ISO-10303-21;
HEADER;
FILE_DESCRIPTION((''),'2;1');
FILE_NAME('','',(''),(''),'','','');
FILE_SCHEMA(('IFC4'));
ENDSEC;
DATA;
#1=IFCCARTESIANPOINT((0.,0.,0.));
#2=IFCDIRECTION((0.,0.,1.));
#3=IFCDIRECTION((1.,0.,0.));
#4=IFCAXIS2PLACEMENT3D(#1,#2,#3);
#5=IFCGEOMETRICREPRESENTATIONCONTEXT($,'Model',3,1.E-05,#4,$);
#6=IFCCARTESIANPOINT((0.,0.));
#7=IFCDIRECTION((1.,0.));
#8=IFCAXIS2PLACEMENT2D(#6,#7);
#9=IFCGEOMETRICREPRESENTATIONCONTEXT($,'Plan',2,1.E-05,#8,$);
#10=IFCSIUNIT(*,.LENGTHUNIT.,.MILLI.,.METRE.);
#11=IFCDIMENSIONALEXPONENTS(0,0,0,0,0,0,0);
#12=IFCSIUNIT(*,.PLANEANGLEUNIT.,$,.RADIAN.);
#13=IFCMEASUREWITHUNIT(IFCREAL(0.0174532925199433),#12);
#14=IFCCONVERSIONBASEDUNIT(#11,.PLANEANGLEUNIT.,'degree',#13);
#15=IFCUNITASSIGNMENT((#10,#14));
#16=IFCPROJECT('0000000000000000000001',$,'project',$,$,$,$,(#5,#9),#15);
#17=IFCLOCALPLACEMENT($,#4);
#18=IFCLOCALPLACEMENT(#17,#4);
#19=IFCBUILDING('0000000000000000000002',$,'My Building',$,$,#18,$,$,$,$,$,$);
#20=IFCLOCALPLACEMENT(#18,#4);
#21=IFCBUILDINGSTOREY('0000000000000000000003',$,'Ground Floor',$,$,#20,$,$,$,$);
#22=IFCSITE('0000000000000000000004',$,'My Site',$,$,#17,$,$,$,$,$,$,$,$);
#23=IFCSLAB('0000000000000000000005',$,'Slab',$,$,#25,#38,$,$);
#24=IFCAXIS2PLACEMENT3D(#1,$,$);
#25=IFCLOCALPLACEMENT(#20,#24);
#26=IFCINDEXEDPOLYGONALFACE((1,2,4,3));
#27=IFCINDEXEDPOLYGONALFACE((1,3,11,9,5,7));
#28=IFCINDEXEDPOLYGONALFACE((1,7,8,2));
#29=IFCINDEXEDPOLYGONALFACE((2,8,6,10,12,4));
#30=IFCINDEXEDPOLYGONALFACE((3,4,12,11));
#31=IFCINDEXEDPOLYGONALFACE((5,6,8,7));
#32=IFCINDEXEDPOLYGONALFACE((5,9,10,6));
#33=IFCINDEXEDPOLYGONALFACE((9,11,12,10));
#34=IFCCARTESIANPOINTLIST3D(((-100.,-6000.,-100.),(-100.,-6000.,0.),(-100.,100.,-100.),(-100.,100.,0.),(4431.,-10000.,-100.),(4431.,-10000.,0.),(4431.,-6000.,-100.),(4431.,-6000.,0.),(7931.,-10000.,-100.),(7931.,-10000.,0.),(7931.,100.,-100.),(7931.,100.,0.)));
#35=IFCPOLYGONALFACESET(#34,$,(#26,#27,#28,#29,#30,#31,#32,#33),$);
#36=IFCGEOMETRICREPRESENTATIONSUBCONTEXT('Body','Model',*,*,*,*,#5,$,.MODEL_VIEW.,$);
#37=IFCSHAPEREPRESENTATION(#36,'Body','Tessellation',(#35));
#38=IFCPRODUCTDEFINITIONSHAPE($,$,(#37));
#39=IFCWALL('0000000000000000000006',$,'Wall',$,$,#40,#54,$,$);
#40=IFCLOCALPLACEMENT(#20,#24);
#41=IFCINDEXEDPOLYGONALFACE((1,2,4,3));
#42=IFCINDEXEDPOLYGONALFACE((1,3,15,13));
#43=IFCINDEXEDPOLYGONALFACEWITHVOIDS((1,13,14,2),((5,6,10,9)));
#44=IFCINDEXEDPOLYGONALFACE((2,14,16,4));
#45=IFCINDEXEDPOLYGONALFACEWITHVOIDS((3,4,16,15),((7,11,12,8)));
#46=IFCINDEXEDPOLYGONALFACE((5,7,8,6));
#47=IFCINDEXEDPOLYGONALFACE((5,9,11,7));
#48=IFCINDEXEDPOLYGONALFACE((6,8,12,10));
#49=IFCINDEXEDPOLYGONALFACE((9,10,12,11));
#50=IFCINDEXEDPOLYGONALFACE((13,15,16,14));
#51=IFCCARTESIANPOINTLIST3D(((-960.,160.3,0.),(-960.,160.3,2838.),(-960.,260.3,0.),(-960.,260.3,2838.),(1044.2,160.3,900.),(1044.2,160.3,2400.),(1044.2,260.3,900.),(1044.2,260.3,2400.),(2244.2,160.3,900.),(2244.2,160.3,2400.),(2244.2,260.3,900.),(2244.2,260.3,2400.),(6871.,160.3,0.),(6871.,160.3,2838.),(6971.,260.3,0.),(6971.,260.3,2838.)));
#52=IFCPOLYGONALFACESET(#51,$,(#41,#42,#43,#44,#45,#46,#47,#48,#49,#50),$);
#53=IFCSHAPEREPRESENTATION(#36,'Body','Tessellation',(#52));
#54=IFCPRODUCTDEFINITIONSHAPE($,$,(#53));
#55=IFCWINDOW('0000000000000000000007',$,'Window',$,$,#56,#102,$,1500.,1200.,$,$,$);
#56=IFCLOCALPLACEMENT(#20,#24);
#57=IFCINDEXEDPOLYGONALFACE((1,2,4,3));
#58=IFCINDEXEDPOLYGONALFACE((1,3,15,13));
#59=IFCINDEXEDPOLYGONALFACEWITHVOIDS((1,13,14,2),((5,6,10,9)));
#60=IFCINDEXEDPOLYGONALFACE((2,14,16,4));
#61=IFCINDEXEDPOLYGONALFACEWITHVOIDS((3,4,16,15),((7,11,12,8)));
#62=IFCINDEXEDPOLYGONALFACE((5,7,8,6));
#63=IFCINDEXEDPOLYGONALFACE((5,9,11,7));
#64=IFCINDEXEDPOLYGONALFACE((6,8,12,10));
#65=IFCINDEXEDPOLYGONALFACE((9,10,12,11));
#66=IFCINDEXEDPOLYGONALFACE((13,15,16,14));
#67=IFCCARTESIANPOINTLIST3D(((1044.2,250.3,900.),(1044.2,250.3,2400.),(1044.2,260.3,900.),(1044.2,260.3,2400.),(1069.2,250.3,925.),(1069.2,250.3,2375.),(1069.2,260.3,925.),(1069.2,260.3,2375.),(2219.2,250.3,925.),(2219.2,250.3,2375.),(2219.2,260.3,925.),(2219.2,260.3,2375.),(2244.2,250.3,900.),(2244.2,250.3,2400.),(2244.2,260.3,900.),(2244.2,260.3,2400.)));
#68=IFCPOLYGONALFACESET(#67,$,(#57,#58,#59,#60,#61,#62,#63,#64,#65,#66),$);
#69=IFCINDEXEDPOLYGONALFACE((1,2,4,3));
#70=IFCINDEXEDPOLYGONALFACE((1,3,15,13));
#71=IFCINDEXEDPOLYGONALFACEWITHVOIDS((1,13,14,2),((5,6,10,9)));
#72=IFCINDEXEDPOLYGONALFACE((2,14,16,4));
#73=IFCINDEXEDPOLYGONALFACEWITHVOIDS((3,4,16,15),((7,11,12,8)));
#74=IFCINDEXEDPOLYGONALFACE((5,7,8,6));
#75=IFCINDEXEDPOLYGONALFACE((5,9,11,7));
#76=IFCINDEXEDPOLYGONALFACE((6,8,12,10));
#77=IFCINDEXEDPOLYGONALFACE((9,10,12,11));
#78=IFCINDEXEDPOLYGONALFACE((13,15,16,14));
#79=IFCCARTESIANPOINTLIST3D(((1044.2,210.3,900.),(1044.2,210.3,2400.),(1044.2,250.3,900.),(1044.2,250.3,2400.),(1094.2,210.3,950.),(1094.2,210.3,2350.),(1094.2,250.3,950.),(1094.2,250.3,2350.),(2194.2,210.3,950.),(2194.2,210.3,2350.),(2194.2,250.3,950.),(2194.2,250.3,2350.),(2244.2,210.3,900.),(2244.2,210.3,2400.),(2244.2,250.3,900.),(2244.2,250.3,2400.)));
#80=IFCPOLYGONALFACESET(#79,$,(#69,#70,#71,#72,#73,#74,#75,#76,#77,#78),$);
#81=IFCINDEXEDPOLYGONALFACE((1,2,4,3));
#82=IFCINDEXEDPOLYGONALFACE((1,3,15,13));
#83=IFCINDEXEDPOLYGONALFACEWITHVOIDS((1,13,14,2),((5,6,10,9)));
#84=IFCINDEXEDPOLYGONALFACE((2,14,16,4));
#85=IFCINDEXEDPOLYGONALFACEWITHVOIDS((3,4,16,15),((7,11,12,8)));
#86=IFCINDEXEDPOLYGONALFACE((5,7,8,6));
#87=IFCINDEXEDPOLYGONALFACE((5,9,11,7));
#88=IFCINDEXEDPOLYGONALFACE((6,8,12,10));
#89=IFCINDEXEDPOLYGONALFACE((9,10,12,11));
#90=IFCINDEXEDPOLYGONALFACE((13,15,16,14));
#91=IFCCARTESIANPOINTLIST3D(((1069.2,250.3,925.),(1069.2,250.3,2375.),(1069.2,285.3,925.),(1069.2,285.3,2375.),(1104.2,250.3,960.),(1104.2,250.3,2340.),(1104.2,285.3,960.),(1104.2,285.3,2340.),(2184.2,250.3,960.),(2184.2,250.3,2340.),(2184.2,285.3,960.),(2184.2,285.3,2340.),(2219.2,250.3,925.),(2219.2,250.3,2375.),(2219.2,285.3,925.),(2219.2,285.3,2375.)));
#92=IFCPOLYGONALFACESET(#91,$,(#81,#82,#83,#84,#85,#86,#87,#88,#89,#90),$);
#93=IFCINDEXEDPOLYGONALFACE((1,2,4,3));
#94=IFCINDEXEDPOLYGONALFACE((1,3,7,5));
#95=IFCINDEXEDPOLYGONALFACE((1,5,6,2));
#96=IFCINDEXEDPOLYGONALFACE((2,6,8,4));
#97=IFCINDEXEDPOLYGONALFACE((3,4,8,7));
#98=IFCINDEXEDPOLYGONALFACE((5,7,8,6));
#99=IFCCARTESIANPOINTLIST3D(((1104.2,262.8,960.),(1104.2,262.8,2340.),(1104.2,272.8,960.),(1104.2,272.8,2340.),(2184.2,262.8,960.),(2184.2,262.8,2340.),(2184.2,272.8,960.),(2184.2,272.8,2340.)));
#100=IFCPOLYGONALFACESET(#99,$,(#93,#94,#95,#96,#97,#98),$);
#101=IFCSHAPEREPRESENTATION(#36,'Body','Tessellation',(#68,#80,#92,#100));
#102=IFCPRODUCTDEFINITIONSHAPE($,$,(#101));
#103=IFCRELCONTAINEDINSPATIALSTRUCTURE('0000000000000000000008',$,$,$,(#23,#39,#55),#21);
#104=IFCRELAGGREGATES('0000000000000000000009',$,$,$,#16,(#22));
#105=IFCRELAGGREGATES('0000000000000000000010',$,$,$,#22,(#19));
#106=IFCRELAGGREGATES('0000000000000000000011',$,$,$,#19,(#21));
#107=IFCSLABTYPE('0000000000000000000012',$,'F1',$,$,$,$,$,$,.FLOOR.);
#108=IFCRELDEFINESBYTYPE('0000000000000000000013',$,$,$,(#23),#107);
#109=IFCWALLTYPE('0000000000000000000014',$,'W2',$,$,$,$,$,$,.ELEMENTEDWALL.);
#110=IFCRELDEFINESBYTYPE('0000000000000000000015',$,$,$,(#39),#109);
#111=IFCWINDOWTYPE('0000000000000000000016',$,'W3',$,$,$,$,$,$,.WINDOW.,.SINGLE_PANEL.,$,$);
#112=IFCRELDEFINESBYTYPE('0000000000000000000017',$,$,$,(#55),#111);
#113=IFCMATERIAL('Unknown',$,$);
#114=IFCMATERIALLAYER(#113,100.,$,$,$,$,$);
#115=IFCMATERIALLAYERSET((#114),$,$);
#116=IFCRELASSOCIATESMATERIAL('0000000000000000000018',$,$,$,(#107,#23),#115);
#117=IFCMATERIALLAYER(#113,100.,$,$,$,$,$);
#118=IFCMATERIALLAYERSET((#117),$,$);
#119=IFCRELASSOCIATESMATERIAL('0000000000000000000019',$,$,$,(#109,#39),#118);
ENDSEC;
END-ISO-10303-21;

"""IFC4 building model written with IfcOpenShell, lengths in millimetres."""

from ifc_helpers import new_model, entity, si_unit, converted_unit, frame, origin_with_axes, origin_2d_with_axis, place, context, subcontext, project, spatial, line, indexed_curve, outline, extrude, clip, halfspace, shape, source, transform, mapped, material, layer, layer_set, layer_usage, type_object, type_shapes, element, fill, save


model = new_model("IFC4")

# Units and contexts
model_context = context("Model", 3, precision=1e-05, world=origin_with_axes())
plan_context = context("Plan", 2, precision=1e-05, world=origin_2d_with_axis())
body_context_1 = subcontext(model_context, "Body", "Model", "MODEL_VIEW")
body_context_2 = subcontext(plan_context, "Body", "Plan", "PLAN_VIEW")
ifc_project = project(units=[si_unit("LENGTHUNIT", "METRE", prefix="MILLI"), converted_unit("PLANEANGLEUNIT", "degree", entity("IfcReal", 0.0174532925199433), si_unit("PLANEANGLEUNIT", "RADIAN"), dimensions=[0, 0, 0, 0, 0, 0, 0])], contexts=[model_context, plan_context])

# Site, building, storey
site_placement = place(None, origin_with_axes())
site = spatial("IfcSite", under=ifc_project, at=site_placement, Name="My Site")
building_placement = place(site_placement, origin_with_axes())
building = spatial("IfcBuilding", under=site, at=building_placement, Name="My Building")
storey_placement = place(building_placement, origin_with_axes())
storey = spatial("IfcBuildingStorey", under=building, at=storey_placement, Name="Ground Floor")

# Slab
ifc_material = material(Name="Unknown")
ifc_layer_1 = layer(ifc_material, 100.0)
ifc_layer_set_1 = layer_set([ifc_layer_1])
ifc_layer_usage_1 = layer_usage(ifc_layer_set_1, "AXIS3", "POSITIVE", -100.0)
slab_type = type_object("IfcSlabType", Name="F1", PredefinedType="FLOOR", material=ifc_layer_set_1)
slab_placement = place(storey_placement, frame((-100.0, 100.0, 0.0), z_axis=(0.0, 0.0, 1.0), x_axis=(1.0, 0.0, 0.0)))
element("IfcSlab", 1, at=slab_placement, inside=storey, type_object=slab_type, material=ifc_layer_usage_1, Name="Slab", context=body_context_1, shape_type="SweptSolid", body=[
    extrude(outline(indexed_curve([(0.0, 0.0), (8031.0, 0.0), (8031.0, -10100.0), (4531.0, -10100.0), (4531.0, -6100.0), (0.0, -6100.0), (0.0, 0.0)])), frame((0.0, 0.0, -100.0), z_axis=(0.0, 0.0, 1.0), x_axis=(1.0, 0.0, 0.0)), (0.0, 0.0, 1.0), 100.0),
])

# Wall, opening, window
ifc_layer_2 = layer(ifc_material, 100.0)
ifc_layer_set_2 = layer_set([ifc_layer_2])
ifc_layer_usage_2 = layer_usage(ifc_layer_set_2, "AXIS2", "POSITIVE", 0.0)
wall_type = type_object("IfcWallType", Name="W2", PredefinedType="ELEMENTEDWALL", material=ifc_layer_set_2)
wall_1_placement = place(storey_placement, frame((-960.0, 160.3, 0.0), z_axis=(0.0, 0.0, 1.0), x_axis=(1.0, 0.0, 0.0)))
wall_1 = element("IfcWall", 2, at=wall_1_placement, inside=storey, type_object=wall_type, material=ifc_layer_usage_2, Name="Wall", context=body_context_1, shape_type="Clipping", body=[
    clip(extrude(outline(indexed_curve([(0.0, 0.0), (0.0, 100.0), (7931.0, 100.0), (7931.0, 0.0), (0.0, 0.0)], self_intersect=False)), origin_with_axes(), (0.0, 0.0, 1.0), 2838.0), halfspace(frame((7831.0, 0.0, 0.0), z_axis=(0.707107, -0.707106, 0.0), x_axis=(-0.707106, -0.707107, 0.0)), False)),
])
shared_shape_1 = source(origin_with_axes(), body_context_1, "Body", "SolidModel", [
    extrude(outline(indexed_curve([(0.0, 0.0), (1200.0, 0.0), (1200.0, 1500.0), (0.0, 1500.0)], segments=[line(1, 2, 3, 4, 1)])), frame((0.0, -600.0, 0.0), z_axis=(0.0, -1.0, 0.0), x_axis=(1.0, 0.0, 0.0)), (0.0, 0.0, -1.0), 1200.0),
])
opening_1_placement = place(wall_1_placement, frame((2004.2, 0.0, 900.0), z_axis=(0.0, 0.0, 1.0), x_axis=(1.0, 0.0, 0.0)))
opening_1 = element("IfcOpeningElement", 3, at=opening_1_placement, cuts=wall_1, PredefinedType="OPENING", context=body_context_1, shape_type="MappedRepresentation", body=[
    mapped(shared_shape_1, transform((0.0, 0.0, 0.0), x_axis=(1.0, 0.0, 0.0), y_axis=(0.0, 1.0, 0.0), z_axis=(0.0, 0.0, 1.0), scale=1.0)),
])
window_type_1 = type_object("IfcWindowType", Name="W3", PartitioningType="SINGLE_PANEL", PredefinedType="WINDOW")
shared_shape_2 = source(origin_with_axes(), body_context_1, "Body", "SolidModel", [
    extrude(outline(indexed_curve([(0.0, 0.0), (1200.0, 0.0), (1200.0, 1500.0), (0.0, 1500.0)], segments=[line(1, 2, 3, 4, 1)]), holes=[indexed_curve([(25.0, 25.0), (1175.0, 25.0), (1175.0, 1475.0), (25.0, 1475.0)], segments=[line(1, 2, 3, 4, 1)])]), frame((0.0, 90.0, 0.0), z_axis=(0.0, -1.0, 0.0), x_axis=(1.0, 0.0, 0.0)), (0.0, 0.0, -1.0), 10.0),
    extrude(outline(indexed_curve([(0.0, 0.0), (1200.0, 0.0), (1200.0, 1500.0), (0.0, 1500.0)], segments=[line(1, 2, 3, 4, 1)]), holes=[indexed_curve([(50.0, 50.0), (1150.0, 50.0), (1150.0, 1450.0), (50.0, 1450.0)], segments=[line(1, 2, 3, 4, 1)])]), frame((0.0, 50.0, 0.0), z_axis=(0.0, -1.0, 0.0), x_axis=(1.0, 0.0, 0.0)), (0.0, 0.0, -1.0), 40.0),
    extrude(outline(indexed_curve([(0.0, 0.0), (1150.0, 0.0), (1150.0, 1450.0), (0.0, 1450.0)], segments=[line(1, 2, 3, 4, 1)]), holes=[indexed_curve([(35.0, 35.0), (1115.0, 35.0), (1115.0, 1415.0), (35.0, 1415.0)], segments=[line(1, 2, 3, 4, 1)])]), frame((25.0, 90.0, 25.0), z_axis=(0.0, -1.0, 0.0), x_axis=(1.0, 0.0, 0.0)), (0.0, 0.0, -1.0), 35.0),
    extrude(outline(indexed_curve([(35.0, 35.0), (1115.0, 35.0), (1115.0, 1415.0), (35.0, 1415.0)], segments=[line(1, 2, 3, 4, 1)])), frame((25.0, 102.5, 25.0), z_axis=(0.0, -1.0, 0.0), x_axis=(1.0, 0.0, 0.0)), (0.0, 0.0, -1.0), 10.0),
])
shared_shape_3 = source(origin_with_axes(), body_context_2, "Body", "Curve2D", [
    entity("IfcIndexedPolyCurve", entity("IfcCartesianPointList2D", [[50.0, 50.0], [1150.0, 50.0]])),
    entity("IfcIndexedPolyCurve", entity("IfcCartesianPointList2D", [[0.0, 100.0], [25.0, 100.0], [25.0, 90.0], [50.0, 90.0], [50.0, 50.0], [0.0, 50.0]]), [entity("IfcLineIndex", [1, 2, 3, 4, 5, 6, 1])]),
    entity("IfcIndexedPolyCurve", entity("IfcCartesianPointList2D", [[1200.0, 100.0], [1175.0, 100.0], [1175.0, 90.0], [1150.0, 90.0], [1150.0, 50.0], [1200.0, 50.0]]), [entity("IfcLineIndex", [1, 2, 3, 4, 5, 6, 1])]),
    entity("IfcIndexedPolyCurve", entity("IfcCartesianPointList2D", [[25.0, 90.0], [60.0, 90.0], [60.0, 125.0], [25.0, 125.0]]), [entity("IfcLineIndex", [1, 2, 3, 4, 1])]),
    entity("IfcIndexedPolyCurve", entity("IfcCartesianPointList2D", [[1175.0, 90.0], [1140.0, 90.0], [1140.0, 125.0], [1175.0, 125.0]]), [entity("IfcLineIndex", [1, 2, 3, 4, 1])]),
    entity("IfcIndexedPolyCurve", entity("IfcCartesianPointList2D", [[60.0, 90.0], [1140.0, 90.0]])),
    entity("IfcIndexedPolyCurve", entity("IfcCartesianPointList2D", [[60.0, 125.0], [1140.0, 125.0]])),
    entity("IfcIndexedPolyCurve", entity("IfcCartesianPointList2D", [[60.0, 107.5], [1140.0, 107.5]])),
])
type_shapes(window_type_1, [shared_shape_2, shared_shape_3])
window_1_placement = place(opening_1_placement, frame((0.0, 0.0, 0.0), z_axis=(0.0, 0.0, 1.0), x_axis=(1.0, 0.0, 0.0)))
window_1 = element("IfcWindow", 4, at=window_1_placement, inside=storey, type_object=window_type_1, Name="Window", OverallHeight=1500.0, OverallWidth=1200.0, shapes=[
    shape(body_context_1, "Body", "MappedRepresentation", [mapped(shared_shape_2, transform((0.0, 0.0, 0.0), x_axis=(1.0, 0.0, 0.0), y_axis=(0.0, 1.0, 0.0), z_axis=(0.0, 0.0, 1.0), scale=1.0))]),
    shape(body_context_2, "Body", "MappedRepresentation", [mapped(shared_shape_3, transform((0.0, 0.0, 0.0), x_axis=(1.0, 0.0, 0.0), y_axis=(0.0, 1.0, 0.0), z_axis=(0.0, 0.0, 1.0), scale=1.0))]),
])
fill(opening_1, window_1)

save(model, "model.ifc")
